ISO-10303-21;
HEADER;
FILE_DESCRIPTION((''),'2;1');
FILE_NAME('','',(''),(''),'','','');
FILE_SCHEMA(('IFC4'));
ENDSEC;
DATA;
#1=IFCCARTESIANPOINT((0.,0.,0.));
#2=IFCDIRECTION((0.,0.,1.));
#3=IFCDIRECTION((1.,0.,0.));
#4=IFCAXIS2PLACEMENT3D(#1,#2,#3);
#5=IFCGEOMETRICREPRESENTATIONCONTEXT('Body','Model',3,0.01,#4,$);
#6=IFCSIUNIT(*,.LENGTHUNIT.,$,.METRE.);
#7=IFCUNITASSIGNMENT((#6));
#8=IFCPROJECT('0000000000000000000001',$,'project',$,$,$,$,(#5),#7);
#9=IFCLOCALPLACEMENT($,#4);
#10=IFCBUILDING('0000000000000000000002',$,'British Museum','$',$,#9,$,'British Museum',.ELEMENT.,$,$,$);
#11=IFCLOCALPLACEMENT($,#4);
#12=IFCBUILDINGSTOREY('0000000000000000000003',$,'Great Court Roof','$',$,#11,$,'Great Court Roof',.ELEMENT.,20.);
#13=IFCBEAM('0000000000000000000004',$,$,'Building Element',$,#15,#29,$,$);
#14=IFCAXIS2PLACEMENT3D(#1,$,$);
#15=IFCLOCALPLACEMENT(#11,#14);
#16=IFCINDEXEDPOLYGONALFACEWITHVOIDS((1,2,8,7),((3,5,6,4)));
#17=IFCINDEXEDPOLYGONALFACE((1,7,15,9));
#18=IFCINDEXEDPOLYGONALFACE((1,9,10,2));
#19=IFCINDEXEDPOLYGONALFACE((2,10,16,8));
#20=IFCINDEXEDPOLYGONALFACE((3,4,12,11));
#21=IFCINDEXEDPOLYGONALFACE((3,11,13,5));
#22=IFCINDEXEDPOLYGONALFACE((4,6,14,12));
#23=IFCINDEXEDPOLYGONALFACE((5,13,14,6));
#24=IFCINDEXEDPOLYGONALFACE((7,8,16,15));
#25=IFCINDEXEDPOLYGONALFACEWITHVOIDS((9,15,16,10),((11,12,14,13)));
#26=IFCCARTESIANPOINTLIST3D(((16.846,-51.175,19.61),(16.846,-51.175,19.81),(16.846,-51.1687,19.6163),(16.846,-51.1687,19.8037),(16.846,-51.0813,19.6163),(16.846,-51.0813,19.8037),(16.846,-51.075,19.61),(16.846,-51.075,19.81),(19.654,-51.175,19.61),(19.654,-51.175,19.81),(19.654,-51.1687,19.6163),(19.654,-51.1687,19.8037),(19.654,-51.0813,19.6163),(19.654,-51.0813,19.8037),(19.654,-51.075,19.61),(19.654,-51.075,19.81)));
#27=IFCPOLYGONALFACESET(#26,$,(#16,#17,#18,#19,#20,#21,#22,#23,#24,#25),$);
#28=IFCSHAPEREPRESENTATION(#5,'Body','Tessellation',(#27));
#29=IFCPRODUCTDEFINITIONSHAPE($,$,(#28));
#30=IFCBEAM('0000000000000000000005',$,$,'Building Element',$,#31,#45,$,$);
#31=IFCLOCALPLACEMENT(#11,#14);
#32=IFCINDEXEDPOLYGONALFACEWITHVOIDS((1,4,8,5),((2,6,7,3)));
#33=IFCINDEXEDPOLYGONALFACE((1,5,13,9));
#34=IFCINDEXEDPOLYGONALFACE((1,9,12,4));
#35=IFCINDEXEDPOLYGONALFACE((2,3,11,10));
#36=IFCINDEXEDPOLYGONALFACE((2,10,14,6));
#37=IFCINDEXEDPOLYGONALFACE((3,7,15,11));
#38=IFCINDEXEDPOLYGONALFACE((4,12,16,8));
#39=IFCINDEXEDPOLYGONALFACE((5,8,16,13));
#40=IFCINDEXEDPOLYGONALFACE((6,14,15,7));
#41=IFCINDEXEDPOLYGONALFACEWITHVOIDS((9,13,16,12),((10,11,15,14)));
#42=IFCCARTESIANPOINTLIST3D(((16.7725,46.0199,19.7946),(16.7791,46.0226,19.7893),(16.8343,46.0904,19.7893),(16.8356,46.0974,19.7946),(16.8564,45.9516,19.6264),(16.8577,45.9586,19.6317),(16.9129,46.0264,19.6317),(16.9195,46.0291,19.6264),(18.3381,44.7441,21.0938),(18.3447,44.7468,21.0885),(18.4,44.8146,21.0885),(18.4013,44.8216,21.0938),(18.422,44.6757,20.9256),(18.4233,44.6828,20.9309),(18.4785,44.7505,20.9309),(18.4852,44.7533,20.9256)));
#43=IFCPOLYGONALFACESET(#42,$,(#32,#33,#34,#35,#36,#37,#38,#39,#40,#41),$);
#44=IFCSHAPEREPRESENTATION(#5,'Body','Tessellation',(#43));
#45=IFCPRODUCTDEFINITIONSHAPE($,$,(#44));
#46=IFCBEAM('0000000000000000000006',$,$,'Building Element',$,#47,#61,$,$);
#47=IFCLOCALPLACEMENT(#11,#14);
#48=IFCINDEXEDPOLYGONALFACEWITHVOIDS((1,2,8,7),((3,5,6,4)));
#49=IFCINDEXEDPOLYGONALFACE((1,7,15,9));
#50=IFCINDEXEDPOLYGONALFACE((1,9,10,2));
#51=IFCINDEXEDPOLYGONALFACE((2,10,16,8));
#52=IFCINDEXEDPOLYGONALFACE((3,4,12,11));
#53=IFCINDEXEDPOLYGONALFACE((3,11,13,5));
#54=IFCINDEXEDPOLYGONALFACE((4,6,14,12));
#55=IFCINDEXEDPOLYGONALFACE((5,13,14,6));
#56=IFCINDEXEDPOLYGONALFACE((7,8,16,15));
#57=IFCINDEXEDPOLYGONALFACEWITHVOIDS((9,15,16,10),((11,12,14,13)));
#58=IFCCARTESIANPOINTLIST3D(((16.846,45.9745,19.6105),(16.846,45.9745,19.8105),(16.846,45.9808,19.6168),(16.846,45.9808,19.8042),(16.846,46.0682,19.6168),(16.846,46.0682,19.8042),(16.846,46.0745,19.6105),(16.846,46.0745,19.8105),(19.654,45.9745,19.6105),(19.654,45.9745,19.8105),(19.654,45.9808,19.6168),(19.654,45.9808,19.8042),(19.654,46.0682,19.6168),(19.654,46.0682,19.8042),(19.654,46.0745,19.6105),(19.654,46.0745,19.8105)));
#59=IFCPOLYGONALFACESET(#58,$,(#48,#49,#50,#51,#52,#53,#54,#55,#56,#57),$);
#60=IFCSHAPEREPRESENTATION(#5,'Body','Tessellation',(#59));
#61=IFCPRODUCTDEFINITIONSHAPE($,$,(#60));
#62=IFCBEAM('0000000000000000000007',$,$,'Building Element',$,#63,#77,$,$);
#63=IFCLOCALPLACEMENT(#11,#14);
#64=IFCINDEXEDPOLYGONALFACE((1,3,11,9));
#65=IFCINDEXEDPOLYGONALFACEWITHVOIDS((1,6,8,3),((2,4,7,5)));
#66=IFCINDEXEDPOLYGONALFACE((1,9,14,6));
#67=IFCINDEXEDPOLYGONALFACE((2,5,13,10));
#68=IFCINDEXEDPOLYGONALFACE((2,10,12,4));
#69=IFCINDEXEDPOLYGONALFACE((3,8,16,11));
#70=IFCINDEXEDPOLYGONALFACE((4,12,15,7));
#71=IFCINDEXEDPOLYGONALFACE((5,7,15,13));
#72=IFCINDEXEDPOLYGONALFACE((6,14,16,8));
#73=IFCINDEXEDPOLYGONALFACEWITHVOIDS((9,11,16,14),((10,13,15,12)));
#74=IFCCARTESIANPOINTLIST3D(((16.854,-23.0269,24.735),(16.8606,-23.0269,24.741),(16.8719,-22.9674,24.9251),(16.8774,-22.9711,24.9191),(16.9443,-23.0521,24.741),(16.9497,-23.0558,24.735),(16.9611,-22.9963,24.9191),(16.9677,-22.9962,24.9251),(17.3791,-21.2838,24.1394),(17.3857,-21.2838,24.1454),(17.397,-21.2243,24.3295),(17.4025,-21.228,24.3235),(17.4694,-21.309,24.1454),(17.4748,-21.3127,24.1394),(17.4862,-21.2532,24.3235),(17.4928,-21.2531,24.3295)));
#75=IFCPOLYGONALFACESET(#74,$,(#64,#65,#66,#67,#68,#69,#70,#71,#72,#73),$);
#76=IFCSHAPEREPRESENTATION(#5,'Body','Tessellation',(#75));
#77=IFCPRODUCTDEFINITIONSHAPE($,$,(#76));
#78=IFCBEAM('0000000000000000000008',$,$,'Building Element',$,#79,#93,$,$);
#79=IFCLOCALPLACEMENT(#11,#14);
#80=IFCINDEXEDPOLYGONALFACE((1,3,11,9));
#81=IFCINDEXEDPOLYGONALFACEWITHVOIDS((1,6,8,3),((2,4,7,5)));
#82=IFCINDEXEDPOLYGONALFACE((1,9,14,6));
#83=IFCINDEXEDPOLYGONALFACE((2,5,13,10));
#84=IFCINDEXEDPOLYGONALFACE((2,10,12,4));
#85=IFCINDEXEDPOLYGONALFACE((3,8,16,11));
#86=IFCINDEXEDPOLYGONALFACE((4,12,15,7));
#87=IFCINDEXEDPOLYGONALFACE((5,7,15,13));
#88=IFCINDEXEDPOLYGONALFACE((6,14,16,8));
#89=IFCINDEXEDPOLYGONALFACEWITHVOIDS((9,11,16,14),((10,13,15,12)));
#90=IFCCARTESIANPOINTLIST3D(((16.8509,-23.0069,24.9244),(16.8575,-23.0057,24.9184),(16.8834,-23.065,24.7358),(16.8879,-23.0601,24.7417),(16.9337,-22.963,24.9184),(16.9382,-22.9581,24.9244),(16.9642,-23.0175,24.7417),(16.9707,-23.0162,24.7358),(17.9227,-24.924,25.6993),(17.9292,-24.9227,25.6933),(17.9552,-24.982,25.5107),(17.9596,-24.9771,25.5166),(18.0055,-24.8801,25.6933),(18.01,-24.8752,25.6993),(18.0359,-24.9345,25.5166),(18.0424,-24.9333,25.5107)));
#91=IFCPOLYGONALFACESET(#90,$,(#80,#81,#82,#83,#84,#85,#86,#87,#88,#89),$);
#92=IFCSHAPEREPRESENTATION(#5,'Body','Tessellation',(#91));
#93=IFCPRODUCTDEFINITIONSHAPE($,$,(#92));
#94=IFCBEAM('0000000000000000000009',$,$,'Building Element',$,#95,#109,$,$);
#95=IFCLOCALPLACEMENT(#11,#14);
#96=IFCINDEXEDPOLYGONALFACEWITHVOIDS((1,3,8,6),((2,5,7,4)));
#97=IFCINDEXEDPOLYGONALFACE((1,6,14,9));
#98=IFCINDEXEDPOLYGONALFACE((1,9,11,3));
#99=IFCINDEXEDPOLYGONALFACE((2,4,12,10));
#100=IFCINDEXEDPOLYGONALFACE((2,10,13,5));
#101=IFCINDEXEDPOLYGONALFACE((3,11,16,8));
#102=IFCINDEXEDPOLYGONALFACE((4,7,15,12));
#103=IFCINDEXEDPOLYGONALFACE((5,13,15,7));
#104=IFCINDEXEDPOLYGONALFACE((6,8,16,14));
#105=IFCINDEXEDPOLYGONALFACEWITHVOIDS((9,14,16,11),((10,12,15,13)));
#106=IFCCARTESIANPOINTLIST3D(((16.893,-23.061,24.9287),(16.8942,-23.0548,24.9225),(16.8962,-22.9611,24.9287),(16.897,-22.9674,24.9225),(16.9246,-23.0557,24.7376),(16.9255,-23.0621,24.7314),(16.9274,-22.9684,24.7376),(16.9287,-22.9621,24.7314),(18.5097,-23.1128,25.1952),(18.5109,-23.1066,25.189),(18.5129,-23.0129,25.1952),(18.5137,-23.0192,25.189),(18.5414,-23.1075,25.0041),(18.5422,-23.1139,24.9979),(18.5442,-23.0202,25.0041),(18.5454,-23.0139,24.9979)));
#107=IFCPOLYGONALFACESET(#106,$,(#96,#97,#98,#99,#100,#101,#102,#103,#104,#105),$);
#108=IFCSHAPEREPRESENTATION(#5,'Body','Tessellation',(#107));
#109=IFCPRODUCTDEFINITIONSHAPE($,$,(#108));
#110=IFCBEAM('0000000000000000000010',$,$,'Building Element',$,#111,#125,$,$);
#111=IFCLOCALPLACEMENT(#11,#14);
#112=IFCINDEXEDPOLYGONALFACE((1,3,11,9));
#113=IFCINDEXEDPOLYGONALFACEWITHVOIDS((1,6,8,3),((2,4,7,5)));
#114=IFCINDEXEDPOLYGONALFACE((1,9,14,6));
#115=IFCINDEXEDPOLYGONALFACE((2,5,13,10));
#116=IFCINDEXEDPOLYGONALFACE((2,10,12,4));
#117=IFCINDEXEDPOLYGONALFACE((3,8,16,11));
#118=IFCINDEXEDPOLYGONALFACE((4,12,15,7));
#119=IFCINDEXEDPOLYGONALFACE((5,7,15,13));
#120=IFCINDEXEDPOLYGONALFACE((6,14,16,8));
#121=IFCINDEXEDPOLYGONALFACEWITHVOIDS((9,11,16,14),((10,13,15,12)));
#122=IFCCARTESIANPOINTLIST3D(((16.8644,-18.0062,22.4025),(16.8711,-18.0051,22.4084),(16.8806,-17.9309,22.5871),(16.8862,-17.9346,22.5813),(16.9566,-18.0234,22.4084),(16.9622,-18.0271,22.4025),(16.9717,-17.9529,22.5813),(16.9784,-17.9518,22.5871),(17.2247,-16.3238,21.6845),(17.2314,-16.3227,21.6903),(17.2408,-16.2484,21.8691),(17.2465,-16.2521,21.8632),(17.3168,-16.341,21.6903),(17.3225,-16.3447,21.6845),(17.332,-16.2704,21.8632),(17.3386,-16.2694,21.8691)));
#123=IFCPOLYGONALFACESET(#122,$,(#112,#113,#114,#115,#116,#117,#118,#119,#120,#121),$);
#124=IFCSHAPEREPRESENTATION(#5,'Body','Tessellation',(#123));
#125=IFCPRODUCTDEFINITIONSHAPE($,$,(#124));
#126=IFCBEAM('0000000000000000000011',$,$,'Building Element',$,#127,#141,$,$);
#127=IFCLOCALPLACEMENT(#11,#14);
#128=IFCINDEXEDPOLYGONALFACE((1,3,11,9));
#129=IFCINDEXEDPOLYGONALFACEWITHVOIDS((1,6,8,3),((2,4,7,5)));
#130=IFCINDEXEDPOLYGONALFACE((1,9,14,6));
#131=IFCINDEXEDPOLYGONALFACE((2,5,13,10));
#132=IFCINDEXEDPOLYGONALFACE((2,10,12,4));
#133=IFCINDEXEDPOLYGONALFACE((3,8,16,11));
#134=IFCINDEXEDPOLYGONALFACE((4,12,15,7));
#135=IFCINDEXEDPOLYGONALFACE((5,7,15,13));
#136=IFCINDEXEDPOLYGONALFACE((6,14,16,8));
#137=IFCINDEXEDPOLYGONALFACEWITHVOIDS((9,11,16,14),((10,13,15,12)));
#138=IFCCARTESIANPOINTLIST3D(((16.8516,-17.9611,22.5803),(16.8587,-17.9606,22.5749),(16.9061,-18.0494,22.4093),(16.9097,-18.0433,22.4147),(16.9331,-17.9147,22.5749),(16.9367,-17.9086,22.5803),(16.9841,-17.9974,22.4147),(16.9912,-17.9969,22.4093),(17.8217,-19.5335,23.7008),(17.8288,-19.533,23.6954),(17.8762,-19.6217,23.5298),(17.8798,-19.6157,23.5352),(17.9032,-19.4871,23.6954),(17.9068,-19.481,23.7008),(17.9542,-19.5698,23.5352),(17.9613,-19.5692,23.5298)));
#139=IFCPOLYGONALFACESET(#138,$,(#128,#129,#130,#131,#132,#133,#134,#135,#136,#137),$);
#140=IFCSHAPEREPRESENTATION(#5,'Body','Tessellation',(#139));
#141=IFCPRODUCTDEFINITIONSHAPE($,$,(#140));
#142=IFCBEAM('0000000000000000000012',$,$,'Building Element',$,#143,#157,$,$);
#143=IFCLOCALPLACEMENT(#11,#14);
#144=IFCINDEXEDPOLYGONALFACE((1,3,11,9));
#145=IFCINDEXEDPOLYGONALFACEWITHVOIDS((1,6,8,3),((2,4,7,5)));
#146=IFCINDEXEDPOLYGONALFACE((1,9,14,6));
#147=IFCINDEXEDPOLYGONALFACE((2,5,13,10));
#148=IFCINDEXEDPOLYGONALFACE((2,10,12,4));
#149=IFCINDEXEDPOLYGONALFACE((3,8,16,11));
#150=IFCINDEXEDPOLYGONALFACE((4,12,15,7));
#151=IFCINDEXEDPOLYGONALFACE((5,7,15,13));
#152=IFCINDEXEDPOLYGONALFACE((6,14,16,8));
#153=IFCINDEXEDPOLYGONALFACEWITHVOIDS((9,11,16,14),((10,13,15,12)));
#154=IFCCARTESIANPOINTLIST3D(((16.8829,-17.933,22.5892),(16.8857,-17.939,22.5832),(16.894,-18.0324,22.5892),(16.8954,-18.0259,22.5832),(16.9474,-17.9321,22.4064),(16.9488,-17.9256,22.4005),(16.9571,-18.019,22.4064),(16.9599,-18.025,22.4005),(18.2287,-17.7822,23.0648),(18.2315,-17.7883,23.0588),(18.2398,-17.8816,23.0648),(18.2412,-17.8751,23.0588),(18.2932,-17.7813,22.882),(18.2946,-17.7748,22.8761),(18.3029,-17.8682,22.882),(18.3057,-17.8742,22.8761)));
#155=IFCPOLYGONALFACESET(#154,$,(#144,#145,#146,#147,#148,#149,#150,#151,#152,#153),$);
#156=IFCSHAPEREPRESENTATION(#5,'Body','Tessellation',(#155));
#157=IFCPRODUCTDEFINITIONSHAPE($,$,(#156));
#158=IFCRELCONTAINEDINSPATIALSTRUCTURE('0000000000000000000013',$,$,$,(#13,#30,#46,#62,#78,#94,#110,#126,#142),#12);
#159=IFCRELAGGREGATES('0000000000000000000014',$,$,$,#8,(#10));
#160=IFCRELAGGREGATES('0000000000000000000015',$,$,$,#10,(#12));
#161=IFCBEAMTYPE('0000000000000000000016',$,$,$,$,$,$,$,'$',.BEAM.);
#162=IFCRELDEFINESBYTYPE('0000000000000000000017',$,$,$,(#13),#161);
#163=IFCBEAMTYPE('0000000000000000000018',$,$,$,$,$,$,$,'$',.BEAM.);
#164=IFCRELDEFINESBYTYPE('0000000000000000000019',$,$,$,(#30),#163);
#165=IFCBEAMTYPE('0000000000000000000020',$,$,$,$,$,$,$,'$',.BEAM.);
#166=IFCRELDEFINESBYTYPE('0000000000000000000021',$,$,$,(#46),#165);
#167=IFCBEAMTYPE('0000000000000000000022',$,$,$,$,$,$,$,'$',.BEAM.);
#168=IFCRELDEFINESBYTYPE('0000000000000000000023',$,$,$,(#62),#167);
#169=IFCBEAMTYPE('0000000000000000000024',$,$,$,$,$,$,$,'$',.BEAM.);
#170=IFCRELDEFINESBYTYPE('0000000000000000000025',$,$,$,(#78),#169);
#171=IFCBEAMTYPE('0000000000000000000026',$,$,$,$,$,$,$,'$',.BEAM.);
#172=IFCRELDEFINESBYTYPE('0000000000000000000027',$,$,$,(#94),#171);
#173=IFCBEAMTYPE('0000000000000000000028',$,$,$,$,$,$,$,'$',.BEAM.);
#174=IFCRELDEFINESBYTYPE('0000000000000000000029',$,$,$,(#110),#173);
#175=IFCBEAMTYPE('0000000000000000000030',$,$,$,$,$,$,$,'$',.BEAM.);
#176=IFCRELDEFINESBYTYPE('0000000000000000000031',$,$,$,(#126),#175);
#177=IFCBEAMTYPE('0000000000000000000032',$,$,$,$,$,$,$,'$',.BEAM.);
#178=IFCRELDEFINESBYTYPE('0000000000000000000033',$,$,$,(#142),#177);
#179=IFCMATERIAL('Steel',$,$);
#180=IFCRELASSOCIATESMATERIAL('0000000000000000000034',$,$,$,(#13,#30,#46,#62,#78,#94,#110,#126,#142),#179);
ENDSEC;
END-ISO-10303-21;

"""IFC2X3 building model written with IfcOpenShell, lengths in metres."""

from ifc_helpers import new_model, si_unit, frame, origin_with_axes, origin_2d, place, context, project, spatial, hollow_rectangle, extrude, material, type_object, element, save


model = new_model("IFC2X3")

# Units and contexts
model_context = context("Model", 3, precision=0.01, world=origin_with_axes(), identifier="Body")
ifc_project = project(units=[si_unit("LENGTHUNIT", "METRE")], contexts=[model_context])

# Building, storey
building_placement = place(None, origin_with_axes())
building = spatial("IfcBuilding", under=ifc_project, at=building_placement, Name="British Museum", Description="$", LongName="British Museum", CompositionType="ELEMENT")
storey_placement = place(None, origin_with_axes())
storey = spatial("IfcBuildingStorey", under=building, at=storey_placement, Name="Great Court Roof", Description="$", LongName="Great Court Roof", CompositionType="ELEMENT", Elevation=20.0)

# Beams
ifc_material = material(Name="Steel")
beam_type_1 = type_object("IfcBeamType", ElementType="$", PredefinedType="BEAM")
beam_1_placement = place(None, origin_with_axes())
element("IfcBeam", 1, at=beam_1_placement, inside=storey, type_object=beam_type_1, material=ifc_material, Description="Building Element", context=model_context, shape_type="SweptSolid", body=[
    extrude(hollow_rectangle(XDim=0.1, YDim=0.2, WallThickness=0.0063, InnerFilletRadius=-0.0063, OuterFilletRadius=0.0, at=origin_2d()), frame((16.846, -51.125, 19.71), z_axis=(1.0, 0.0, 0.0), x_axis=(0.0, 1.0, 0.0)), (0.0, 0.0, 1.0), 2.808),
])
beam_type_2 = type_object("IfcBeamType", ElementType="$", PredefinedType="BEAM")
beam_2_placement = place(None, origin_with_axes())
element("IfcBeam", 2, at=beam_2_placement, inside=storey, type_object=beam_type_2, material=ifc_material, Description="Building Element", context=model_context, shape_type="SweptSolid", body=[
    extrude(hollow_rectangle(XDim=0.1, YDim=0.2, WallThickness=0.0063, InnerFilletRadius=-0.0063, OuterFilletRadius=0.0, at=origin_2d()), frame((16.846, 46.0245, 19.7105), z_axis=(0.651974, -0.531285, 0.540986), x_axis=(0.631707, 0.775207, 0.0)), (0.0, 0.0, 1.0), 2.4014),
])
beam_type_3 = type_object("IfcBeamType", ElementType="$", PredefinedType="BEAM")
beam_3_placement = place(None, origin_with_axes())
element("IfcBeam", 3, at=beam_3_placement, inside=storey, type_object=beam_type_3, material=ifc_material, Description="Building Element", context=model_context, shape_type="SweptSolid", body=[
    extrude(hollow_rectangle(XDim=0.1, YDim=0.2, WallThickness=0.0063, InnerFilletRadius=-0.0063, OuterFilletRadius=0.0, at=origin_2d()), frame((16.846, 46.0245, 19.7105), z_axis=(1.0, 0.0, -0.000009), x_axis=(0.0, 1.0, 0.0)), (0.0, 0.0, 1.0), 2.808),
])
beam_type_4 = type_object("IfcBeamType", ElementType="$", PredefinedType="BEAM")
beam_4_placement = place(None, origin_with_axes())
element("IfcBeam", 4, at=beam_4_placement, inside=storey, type_object=beam_type_4, material=ifc_material, Description="Building Element", context=model_context, shape_type="SweptSolid", body=[
    extrude(hollow_rectangle(XDim=0.1, YDim=0.2, WallThickness=0.0063, InnerFilletRadius=-0.0063, OuterFilletRadius=0.0, at=origin_2d()), frame((16.9108, -23.0116, 24.8301), z_axis=(0.274145, 0.910029, -0.310953), x_axis=(-0.957497, 0.288444, 0.0)), (0.0, 0.0, 1.0), 1.9154),
])
beam_type_5 = type_object("IfcBeamType", ElementType="$", PredefinedType="BEAM")
beam_5_placement = place(None, origin_with_axes())
element("IfcBeam", 5, at=beam_5_placement, inside=storey, type_object=beam_type_5, material=ifc_material, Description="Building Element", context=model_context, shape_type="SweptSolid", body=[
    extrude(hollow_rectangle(XDim=0.1, YDim=0.2, WallThickness=0.0063, InnerFilletRadius=-0.0063, OuterFilletRadius=0.0, at=origin_2d()), frame((16.9108, -23.0116, 24.8301), z_axis=(0.460176, -0.823123, 0.332724), x_axis=(0.872855, 0.487979, 0.0)), (0.0, 0.0, 1.0), 2.329),
])
beam_type_6 = type_object("IfcBeamType", ElementType="$", PredefinedType="BEAM")
beam_6_placement = place(None, origin_with_axes())
element("IfcBeam", 6, at=beam_6_placement, inside=storey, type_object=beam_type_6, material=ifc_material, Description="Building Element", context=model_context, shape_type="SweptSolid", body=[
    extrude(hollow_rectangle(XDim=0.1, YDim=0.2, WallThickness=0.0063, InnerFilletRadius=-0.0063, OuterFilletRadius=0.0, at=origin_2d()), frame((16.9108, -23.0116, 24.8301), z_axis=(0.986195, -0.031598, 0.162543), x_axis=(0.032024, 0.999487, 0.0)), (0.0, 0.0, 1.0), 1.6394),
])
beam_type_7 = type_object("IfcBeamType", ElementType="$", PredefinedType="BEAM")
beam_7_placement = place(None, origin_with_axes())
element("IfcBeam", 7, at=beam_7_placement, inside=storey, type_object=beam_type_7, material=ifc_material, Description="Building Element", context=model_context, shape_type="SweptSolid", body=[
    extrude(hollow_rectangle(XDim=0.1, YDim=0.2, WallThickness=0.0063, InnerFilletRadius=-0.0063, OuterFilletRadius=0.0, at=origin_2d()), frame((16.9214, -17.979, 22.4948), z_axis=(0.19324, 0.9024, -0.38514), x_axis=(-0.977832, 0.209393, 0.0)), (0.0, 0.0, 1.0), 1.8644),
])
beam_type_8 = type_object("IfcBeamType", ElementType="$", PredefinedType="BEAM")
beam_8_placement = place(None, origin_with_axes())
element("IfcBeam", 8, at=beam_8_placement, inside=storey, type_object=beam_type_8, material=ifc_material, Description="Building Element", context=model_context, shape_type="SweptSolid", body=[
    extrude(hollow_rectangle(XDim=0.1, YDim=0.2, WallThickness=0.0063, InnerFilletRadius=-0.0063, OuterFilletRadius=0.0, at=origin_2d()), frame((16.9214, -17.979, 22.4948), z_axis=(0.44896, -0.72769, 0.518557), x_axis=(0.851057, 0.525073, 0.0)), (0.0, 0.0, 1.0), 2.1608),
])
beam_type_9 = type_object("IfcBeamType", ElementType="$", PredefinedType="BEAM")
beam_9_placement = place(None, origin_with_axes())
element("IfcBeam", 9, at=beam_9_placement, inside=storey, type_object=beam_type_9, material=ifc_material, Description="Building Element", context=model_context, shape_type="SweptSolid", body=[
    extrude(hollow_rectangle(XDim=0.1, YDim=0.2, WallThickness=0.0063, InnerFilletRadius=-0.0063, OuterFilletRadius=0.0, at=origin_2d()), frame((16.9214, -17.979, 22.4948), z_axis=(0.937639, 0.105051, 0.331356), x_axis=(-0.111341, 0.993782, 0.0)), (0.0, 0.0, 1.0), 1.4353),
])

save(model, "model.ifc")
